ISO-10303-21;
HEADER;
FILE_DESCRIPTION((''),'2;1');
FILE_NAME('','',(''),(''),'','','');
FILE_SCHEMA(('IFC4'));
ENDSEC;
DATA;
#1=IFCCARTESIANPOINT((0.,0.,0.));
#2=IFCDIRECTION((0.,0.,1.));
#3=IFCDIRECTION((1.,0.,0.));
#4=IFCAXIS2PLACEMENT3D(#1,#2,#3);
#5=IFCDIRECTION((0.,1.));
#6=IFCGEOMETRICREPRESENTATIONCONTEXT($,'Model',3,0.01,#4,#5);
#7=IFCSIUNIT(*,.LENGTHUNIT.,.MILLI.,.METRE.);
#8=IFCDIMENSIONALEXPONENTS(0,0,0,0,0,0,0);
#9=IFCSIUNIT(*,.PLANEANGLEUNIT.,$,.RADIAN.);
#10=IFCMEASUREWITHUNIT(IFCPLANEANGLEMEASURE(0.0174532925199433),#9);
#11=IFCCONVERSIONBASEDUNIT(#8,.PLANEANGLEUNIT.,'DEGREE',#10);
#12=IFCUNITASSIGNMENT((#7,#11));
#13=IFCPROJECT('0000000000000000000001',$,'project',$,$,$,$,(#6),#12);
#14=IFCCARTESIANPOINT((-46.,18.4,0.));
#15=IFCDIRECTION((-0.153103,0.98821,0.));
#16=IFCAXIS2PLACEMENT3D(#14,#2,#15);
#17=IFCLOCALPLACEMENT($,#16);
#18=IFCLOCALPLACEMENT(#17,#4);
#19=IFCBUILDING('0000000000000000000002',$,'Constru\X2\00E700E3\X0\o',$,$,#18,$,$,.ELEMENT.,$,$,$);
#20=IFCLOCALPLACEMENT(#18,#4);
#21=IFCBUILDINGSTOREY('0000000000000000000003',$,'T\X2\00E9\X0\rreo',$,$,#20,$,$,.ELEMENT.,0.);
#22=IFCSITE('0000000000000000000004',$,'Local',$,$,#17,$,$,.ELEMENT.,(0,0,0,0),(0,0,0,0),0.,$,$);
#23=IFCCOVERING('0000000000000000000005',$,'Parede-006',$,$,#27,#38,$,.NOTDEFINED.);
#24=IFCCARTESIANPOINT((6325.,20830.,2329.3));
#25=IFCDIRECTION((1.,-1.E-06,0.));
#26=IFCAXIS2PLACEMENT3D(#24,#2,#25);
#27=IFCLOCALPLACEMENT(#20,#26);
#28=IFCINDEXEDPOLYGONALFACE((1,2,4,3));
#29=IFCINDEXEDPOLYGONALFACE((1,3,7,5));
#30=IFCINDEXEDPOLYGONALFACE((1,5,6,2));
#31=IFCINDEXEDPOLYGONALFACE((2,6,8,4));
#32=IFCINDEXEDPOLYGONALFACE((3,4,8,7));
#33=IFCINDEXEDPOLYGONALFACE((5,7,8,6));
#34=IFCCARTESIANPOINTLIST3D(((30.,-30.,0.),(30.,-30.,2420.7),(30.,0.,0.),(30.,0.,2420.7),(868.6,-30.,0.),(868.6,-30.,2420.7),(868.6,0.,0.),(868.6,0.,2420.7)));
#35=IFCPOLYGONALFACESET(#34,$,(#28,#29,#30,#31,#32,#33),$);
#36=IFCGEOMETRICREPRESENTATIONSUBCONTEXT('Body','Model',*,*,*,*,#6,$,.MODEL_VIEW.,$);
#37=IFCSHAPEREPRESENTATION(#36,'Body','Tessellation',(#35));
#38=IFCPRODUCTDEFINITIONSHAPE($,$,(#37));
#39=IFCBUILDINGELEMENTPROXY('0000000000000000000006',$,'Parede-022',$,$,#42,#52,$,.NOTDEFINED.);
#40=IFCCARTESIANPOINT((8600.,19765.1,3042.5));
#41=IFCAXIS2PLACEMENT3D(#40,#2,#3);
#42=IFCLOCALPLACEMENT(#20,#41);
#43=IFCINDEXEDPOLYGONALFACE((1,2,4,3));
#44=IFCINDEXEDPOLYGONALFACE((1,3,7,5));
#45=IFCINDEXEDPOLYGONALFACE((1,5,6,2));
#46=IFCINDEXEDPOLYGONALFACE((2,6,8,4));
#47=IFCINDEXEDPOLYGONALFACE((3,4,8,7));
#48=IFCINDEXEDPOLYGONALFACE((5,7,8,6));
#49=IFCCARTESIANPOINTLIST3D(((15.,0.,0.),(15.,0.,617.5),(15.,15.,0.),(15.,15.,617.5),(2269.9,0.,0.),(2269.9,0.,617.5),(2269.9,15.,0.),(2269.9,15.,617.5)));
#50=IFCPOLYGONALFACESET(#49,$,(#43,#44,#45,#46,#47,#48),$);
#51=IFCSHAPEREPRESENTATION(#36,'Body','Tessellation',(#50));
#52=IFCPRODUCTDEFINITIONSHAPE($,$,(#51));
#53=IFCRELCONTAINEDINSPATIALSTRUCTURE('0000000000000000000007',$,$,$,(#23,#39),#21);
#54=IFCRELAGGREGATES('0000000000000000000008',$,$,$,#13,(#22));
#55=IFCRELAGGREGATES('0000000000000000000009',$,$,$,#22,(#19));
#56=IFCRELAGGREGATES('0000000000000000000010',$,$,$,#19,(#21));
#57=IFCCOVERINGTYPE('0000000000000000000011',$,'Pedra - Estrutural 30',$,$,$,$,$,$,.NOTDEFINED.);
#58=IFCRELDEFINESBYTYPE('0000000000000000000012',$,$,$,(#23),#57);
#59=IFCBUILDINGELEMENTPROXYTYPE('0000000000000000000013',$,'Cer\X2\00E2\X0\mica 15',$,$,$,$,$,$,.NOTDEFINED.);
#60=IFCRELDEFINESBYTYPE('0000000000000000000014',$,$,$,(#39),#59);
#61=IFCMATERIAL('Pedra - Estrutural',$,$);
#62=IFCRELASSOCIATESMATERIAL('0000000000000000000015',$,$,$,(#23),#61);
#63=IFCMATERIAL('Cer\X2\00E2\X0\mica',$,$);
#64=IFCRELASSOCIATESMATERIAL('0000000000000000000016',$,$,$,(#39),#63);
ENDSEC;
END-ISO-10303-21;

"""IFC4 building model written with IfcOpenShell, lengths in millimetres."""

from ifc_helpers import new_model, entity, si_unit, converted_unit, direction, frame, origin_with_axes, place, context, subcontext, project, spatial, line, indexed_curve, outline, extrude, material, type_object, element, save


model = new_model("IFC4")

# Units and contexts
model_context = context("Model", 3, precision=0.01, world=origin_with_axes(), true_north=direction((0.0, 1.0)))
body_context = subcontext(model_context, "Body", "Model", "MODEL_VIEW")
ifc_project = project(units=[si_unit("LENGTHUNIT", "METRE", prefix="MILLI"), converted_unit("PLANEANGLEUNIT", "DEGREE", entity("IfcPlaneAngleMeasure", 0.0174532925199433), si_unit("PLANEANGLEUNIT", "RADIAN"), dimensions=[0, 0, 0, 0, 0, 0, 0])], contexts=[model_context])

# Site, building, storey
site_placement = place(None, frame((-46.0, 18.4, 0.0), z_axis=(0.0, 0.0, 1.0), x_axis=(-0.153103, 0.98821, 0.0)))
site = spatial("IfcSite", under=ifc_project, at=site_placement, Name="Local", CompositionType="ELEMENT", RefLatitude=(0, 0, 0, 0), RefLongitude=(0, 0, 0, 0), RefElevation=0.0)
building_placement = place(site_placement, origin_with_axes())
building = spatial("IfcBuilding", under=site, at=building_placement, Name="Construção", CompositionType="ELEMENT")
storey_placement = place(building_placement, origin_with_axes())
storey = spatial("IfcBuildingStorey", under=building, at=storey_placement, Name="Térreo", CompositionType="ELEMENT", Elevation=0.0)

# Covering
ifc_material_1 = material(Name="Pedra - Estrutural")
covering_type_1 = type_object("IfcCoveringType", Name="Pedra - Estrutural 30", PredefinedType="NOTDEFINED")
covering_1_placement = place(storey_placement, frame((6325.0, 20830.0, 2329.3), z_axis=(0.0, 0.0, 1.0), x_axis=(1.0, -0.000001, 0.0)))
element("IfcCovering", 1, at=covering_1_placement, inside=storey, type_object=covering_type_1, material=ifc_material_1, Name="Parede-006", PredefinedType="NOTDEFINED", context=body_context, shape_type="SweptSolid", body=[
    extrude(outline(indexed_curve([(30.0, -30.0), (868.6, -30.0), (868.6, 0.0), (30.0, 0.0)], segments=[line(1, 2, 3, 4, 1)])), origin_with_axes(), (0.0, 0.0, 1.0), 2420.7),
])

# Building element proxy
ifc_material_2 = material(Name="Cerâmica")
building_element_proxy_type_1 = type_object("IfcBuildingElementProxyType", Name="Cerâmica 15", PredefinedType="NOTDEFINED")
proxy_1_placement = place(storey_placement, frame((8600.0, 19765.1, 3042.5), z_axis=(0.0, 0.0, 1.0), x_axis=(1.0, 0.0, 0.0)))
element("IfcBuildingElementProxy", 2, at=proxy_1_placement, inside=storey, type_object=building_element_proxy_type_1, material=ifc_material_2, Name="Parede-022", PredefinedType="NOTDEFINED", context=body_context, shape_type="SweptSolid", body=[
    extrude(outline(indexed_curve([(15.0, 0.0), (2269.9, 0.0), (2269.9, 15.0), (15.0, 15.0)], segments=[line(1, 2, 3, 4, 1)])), origin_with_axes(), (0.0, 0.0, 1.0), 617.5),
])

save(model, "model.ifc")
